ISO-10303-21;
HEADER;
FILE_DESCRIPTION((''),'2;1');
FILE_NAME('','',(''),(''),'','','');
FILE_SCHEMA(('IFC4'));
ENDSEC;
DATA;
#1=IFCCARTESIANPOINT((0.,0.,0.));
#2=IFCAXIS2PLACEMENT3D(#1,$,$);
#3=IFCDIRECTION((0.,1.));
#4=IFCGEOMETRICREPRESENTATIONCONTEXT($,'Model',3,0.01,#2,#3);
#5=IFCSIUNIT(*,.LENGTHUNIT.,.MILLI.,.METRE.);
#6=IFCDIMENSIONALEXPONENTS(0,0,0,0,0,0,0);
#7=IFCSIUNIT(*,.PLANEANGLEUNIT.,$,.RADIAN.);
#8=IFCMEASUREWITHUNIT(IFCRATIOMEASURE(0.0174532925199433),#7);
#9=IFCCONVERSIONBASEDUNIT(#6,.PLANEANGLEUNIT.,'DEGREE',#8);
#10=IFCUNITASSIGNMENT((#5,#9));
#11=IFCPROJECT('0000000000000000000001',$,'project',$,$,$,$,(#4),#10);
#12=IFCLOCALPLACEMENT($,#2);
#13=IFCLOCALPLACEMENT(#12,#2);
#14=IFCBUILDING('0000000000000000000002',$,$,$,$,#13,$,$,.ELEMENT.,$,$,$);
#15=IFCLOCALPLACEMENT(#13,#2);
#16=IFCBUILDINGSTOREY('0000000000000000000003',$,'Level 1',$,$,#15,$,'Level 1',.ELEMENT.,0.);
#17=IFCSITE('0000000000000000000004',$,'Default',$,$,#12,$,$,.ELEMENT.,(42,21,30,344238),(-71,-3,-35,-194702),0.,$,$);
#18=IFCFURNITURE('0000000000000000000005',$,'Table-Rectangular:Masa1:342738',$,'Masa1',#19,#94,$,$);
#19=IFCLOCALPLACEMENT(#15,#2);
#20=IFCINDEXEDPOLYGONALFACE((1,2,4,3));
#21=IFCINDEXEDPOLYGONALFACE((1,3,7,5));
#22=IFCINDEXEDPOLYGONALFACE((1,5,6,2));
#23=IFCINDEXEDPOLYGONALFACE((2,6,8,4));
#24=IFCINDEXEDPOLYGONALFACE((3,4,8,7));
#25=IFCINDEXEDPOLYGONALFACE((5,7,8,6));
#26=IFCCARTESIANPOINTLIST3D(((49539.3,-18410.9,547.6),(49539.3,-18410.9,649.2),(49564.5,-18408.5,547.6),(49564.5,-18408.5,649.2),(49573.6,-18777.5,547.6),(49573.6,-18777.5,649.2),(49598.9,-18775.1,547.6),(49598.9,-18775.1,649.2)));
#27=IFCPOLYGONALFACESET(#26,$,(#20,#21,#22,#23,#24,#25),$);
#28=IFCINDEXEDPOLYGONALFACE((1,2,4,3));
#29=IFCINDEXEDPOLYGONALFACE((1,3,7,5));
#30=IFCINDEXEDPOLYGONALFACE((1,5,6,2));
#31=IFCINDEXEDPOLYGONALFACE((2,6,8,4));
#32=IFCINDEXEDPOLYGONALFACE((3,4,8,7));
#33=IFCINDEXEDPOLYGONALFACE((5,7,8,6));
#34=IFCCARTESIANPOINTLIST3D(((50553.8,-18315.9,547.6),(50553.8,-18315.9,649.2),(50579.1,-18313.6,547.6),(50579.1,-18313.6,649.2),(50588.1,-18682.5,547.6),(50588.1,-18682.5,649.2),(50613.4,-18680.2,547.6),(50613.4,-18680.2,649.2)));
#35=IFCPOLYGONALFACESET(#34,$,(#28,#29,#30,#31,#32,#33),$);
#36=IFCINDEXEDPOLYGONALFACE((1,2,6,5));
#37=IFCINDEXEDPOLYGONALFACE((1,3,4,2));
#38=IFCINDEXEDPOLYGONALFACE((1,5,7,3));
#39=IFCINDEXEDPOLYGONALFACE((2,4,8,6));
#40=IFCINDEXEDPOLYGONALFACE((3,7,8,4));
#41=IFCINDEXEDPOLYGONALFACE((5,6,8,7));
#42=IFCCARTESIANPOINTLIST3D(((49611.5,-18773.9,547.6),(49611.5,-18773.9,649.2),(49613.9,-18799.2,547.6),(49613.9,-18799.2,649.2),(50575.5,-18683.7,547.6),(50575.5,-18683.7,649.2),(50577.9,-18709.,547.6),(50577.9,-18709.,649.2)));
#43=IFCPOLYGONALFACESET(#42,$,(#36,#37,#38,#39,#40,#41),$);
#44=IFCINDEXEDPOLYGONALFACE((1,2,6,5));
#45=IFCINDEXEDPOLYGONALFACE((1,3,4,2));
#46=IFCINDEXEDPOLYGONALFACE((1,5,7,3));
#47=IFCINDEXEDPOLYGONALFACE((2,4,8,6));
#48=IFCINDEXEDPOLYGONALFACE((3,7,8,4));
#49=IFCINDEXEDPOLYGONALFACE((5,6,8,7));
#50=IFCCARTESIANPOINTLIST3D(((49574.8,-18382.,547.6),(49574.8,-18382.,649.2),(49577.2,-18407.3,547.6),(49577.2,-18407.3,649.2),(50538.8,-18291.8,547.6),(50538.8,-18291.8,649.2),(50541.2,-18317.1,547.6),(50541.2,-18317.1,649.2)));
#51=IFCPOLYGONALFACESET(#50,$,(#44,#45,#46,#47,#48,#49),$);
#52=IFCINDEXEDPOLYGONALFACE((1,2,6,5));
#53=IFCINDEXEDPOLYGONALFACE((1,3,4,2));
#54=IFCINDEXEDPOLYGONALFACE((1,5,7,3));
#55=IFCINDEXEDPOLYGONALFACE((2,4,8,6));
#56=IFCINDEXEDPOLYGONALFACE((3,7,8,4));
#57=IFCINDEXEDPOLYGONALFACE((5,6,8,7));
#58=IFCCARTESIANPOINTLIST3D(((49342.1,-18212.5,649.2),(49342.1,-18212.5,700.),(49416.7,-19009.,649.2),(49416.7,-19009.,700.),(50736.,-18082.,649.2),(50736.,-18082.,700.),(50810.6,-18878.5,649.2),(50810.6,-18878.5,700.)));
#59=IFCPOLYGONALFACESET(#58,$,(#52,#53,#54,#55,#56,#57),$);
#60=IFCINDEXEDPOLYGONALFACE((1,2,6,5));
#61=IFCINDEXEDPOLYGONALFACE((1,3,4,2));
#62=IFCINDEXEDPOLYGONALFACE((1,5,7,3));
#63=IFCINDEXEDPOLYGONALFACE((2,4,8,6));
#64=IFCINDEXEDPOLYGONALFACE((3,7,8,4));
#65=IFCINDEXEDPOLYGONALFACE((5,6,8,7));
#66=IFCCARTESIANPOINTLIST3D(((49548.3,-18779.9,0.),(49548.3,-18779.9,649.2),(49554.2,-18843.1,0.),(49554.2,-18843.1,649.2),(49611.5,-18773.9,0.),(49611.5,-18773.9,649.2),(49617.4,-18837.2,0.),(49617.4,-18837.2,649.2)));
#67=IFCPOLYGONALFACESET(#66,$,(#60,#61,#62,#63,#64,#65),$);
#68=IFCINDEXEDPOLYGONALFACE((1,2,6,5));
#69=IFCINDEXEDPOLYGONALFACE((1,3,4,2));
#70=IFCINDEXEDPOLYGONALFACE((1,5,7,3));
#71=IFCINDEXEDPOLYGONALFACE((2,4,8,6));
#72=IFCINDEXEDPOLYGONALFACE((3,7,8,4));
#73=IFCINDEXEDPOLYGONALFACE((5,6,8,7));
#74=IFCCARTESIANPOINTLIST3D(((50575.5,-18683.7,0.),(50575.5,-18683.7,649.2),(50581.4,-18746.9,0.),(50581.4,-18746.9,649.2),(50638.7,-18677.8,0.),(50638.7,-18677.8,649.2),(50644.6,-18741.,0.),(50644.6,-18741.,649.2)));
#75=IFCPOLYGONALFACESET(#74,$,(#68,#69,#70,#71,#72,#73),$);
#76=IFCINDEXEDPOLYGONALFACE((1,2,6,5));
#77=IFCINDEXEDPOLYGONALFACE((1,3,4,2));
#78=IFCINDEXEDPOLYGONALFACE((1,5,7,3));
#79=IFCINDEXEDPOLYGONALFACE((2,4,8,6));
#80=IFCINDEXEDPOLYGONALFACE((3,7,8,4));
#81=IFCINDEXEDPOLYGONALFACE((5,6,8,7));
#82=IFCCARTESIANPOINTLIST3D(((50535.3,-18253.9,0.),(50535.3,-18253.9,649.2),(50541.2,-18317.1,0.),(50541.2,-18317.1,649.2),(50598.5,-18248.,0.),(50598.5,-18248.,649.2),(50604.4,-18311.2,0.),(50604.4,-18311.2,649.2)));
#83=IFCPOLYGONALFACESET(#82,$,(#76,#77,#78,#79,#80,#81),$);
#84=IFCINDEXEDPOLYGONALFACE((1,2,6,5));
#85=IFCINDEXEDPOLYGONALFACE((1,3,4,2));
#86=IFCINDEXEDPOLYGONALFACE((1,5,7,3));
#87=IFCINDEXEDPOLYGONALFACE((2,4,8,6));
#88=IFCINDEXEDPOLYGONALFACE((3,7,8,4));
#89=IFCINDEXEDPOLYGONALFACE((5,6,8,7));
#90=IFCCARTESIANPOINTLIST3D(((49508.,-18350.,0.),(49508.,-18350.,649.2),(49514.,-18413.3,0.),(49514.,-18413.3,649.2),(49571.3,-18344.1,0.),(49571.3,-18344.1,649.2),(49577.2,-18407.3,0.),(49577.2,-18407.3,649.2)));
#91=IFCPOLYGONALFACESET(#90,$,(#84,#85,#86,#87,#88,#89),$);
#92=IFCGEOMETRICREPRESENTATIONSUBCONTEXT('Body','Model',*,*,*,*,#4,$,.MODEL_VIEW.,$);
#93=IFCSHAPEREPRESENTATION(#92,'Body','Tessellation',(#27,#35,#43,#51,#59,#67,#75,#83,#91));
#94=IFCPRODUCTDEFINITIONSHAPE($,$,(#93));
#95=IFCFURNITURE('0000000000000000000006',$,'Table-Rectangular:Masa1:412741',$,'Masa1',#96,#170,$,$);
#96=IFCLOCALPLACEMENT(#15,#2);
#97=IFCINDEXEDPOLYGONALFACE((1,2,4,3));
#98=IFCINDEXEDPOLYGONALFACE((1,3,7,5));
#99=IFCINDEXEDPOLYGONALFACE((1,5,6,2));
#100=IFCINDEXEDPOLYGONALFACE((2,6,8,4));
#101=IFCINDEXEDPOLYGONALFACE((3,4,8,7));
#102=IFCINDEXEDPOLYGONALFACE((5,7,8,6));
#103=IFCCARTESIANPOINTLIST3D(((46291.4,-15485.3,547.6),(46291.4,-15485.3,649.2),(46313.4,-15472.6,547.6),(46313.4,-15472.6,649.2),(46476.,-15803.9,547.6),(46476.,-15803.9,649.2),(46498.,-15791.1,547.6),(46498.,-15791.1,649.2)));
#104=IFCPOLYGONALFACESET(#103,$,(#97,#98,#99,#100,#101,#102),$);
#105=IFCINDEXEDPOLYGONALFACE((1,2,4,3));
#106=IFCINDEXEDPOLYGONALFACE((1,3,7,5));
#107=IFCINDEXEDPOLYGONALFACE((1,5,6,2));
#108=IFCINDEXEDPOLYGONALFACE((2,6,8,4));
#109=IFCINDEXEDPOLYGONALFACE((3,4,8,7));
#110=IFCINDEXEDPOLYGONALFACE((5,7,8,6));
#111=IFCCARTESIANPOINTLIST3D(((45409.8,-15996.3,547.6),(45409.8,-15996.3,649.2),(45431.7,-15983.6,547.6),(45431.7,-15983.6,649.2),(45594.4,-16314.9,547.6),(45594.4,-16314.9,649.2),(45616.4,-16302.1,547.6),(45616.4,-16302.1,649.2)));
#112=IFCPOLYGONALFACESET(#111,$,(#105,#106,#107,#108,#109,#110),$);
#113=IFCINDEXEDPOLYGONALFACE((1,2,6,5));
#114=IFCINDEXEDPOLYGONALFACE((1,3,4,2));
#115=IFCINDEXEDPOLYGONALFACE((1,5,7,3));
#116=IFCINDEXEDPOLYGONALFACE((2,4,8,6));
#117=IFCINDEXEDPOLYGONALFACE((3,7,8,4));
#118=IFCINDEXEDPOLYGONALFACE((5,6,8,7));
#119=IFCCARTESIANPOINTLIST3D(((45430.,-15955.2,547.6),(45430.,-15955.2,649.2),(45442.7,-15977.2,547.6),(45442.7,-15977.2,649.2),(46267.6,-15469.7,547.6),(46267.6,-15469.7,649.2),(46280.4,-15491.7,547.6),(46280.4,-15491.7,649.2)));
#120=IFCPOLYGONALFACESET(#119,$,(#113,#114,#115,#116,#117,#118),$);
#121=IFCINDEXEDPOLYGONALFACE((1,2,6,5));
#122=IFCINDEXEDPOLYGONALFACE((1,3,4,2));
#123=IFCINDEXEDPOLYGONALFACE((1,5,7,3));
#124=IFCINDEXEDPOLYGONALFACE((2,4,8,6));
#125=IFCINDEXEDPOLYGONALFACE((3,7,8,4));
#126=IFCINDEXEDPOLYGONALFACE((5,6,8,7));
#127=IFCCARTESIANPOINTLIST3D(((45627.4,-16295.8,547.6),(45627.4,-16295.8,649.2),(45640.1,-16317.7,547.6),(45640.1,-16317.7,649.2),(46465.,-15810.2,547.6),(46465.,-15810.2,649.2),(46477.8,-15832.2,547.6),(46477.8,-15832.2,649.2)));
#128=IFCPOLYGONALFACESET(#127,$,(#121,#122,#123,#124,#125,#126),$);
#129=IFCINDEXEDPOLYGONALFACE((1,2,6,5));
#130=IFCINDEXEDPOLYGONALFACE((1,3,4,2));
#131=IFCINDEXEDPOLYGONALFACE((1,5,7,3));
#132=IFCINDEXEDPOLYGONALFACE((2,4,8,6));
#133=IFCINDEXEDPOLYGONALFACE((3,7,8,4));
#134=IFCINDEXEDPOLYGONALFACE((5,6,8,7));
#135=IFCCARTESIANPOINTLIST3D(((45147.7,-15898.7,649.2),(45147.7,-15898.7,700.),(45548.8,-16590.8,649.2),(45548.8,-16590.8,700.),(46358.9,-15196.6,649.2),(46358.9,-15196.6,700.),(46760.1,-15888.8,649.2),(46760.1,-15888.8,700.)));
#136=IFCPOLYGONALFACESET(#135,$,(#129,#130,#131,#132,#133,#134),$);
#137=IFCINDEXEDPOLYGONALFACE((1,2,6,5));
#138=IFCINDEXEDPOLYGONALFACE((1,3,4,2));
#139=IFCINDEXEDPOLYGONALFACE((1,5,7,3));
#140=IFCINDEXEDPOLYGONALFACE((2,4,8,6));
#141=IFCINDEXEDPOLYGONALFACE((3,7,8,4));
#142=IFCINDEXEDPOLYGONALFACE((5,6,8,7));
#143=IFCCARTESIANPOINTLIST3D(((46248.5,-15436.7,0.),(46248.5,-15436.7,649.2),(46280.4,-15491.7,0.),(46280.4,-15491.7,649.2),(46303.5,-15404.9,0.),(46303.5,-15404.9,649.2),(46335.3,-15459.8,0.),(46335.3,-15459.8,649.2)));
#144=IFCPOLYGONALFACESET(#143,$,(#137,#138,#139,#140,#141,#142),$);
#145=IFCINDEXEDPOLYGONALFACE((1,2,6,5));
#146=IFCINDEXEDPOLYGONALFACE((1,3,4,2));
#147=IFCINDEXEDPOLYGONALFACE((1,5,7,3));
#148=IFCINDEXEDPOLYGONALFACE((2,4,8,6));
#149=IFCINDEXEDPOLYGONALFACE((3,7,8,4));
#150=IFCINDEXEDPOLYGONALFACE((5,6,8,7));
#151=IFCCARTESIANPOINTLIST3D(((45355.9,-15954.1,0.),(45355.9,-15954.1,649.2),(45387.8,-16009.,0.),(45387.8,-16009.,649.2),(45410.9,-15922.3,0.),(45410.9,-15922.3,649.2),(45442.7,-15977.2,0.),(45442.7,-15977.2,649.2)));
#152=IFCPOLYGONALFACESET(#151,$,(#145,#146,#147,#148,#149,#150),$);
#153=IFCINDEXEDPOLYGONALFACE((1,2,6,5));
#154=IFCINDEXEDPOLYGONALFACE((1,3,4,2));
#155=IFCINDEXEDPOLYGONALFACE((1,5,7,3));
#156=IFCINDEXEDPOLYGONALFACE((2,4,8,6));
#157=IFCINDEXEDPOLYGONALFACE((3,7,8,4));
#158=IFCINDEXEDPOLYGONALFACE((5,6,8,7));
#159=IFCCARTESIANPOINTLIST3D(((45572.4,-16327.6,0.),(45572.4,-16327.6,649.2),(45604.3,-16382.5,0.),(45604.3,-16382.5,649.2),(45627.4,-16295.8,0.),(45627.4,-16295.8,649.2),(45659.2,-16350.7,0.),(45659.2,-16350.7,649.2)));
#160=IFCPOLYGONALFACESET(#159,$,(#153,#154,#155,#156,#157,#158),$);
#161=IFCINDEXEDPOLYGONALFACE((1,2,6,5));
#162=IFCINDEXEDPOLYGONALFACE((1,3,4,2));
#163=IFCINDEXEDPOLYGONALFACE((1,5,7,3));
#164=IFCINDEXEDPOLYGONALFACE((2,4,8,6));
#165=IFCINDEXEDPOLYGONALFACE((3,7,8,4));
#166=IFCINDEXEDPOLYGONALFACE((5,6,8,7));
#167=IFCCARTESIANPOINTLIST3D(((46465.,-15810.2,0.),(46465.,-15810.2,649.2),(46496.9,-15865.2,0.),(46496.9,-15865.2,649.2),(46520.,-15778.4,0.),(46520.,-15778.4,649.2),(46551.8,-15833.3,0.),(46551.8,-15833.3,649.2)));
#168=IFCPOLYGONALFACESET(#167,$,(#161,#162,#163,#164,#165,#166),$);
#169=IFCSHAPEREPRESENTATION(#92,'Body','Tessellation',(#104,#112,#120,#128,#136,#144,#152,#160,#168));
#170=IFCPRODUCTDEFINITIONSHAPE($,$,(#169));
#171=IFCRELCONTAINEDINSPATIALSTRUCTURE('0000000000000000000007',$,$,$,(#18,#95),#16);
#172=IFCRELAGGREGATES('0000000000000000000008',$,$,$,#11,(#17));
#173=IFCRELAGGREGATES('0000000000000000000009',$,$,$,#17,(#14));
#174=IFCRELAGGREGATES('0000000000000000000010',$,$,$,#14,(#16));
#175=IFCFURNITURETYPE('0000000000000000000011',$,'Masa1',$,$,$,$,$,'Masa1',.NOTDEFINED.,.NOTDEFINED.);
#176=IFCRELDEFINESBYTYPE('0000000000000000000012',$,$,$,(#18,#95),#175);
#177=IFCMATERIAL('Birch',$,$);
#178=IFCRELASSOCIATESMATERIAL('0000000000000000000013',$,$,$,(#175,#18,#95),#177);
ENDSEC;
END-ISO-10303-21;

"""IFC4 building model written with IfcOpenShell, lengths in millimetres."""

from ifc_helpers import new_model, entity, si_unit, converted_unit, direction, frame, frame_2d, origin, origin_2d_with_axis, place, context, subcontext, project, spatial, rectangle, extrude, source, transform, mapped, material, type_object, type_shapes, element, save


model = new_model("IFC4")

# Units and contexts
model_context = context("Model", 3, precision=0.01, world=origin(), true_north=direction((0.0, 1.0)))
body_context = subcontext(model_context, "Body", "Model", "MODEL_VIEW")
ifc_project = project(units=[si_unit("LENGTHUNIT", "METRE", prefix="MILLI"), converted_unit("PLANEANGLEUNIT", "DEGREE", entity("IfcRatioMeasure", 0.0174532925199433), si_unit("PLANEANGLEUNIT", "RADIAN"), dimensions=[0, 0, 0, 0, 0, 0, 0])], contexts=[model_context])

# Site, building, storey
site_placement = place(None, origin())
site = spatial("IfcSite", under=ifc_project, at=site_placement, Name="Default", CompositionType="ELEMENT", RefLatitude=(42, 21, 30, 344238), RefLongitude=(-71, -3, -35, -194702), RefElevation=0.0)
building_placement = place(site_placement, origin())
building = spatial("IfcBuilding", under=site, at=building_placement, CompositionType="ELEMENT")
storey_placement = place(building_placement, origin())
storey = spatial("IfcBuildingStorey", under=building, at=storey_placement, Name="Level 1", LongName="Level 1", CompositionType="ELEMENT", Elevation=0.0)

# Furniture
ifc_material_1 = material(Name="Birch")
furniture_type_1 = type_object("IfcFurnitureType", Name="Masa1", ElementType="Masa1", AssemblyPlace="NOTDEFINED", PredefinedType="NOTDEFINED", material=ifc_material_1)
shared_shape_1 = source(origin(), body_context, "Body", "SweptSolid", [
    extrude(rectangle(XDim=25.4, YDim=368.2, at=origin_2d_with_axis()), frame((509.5, 0.0, 547.6)), (0.0, 0.0, 1.0), 101.6),
    extrude(rectangle(XDim=368.2, YDim=25.4, at=origin_2d_with_axis()), frame((-509.5, 0.0, 547.6), z_axis=(0.0, 0.0, 1.0), x_axis=(0.0, 1.0, 0.0)), (0.0, 0.0, 1.0), 101.6),
    extrude(rectangle(XDim=968.2, YDim=25.4, at=frame_2d((0.0, 0.0), x_axis=(1.0, 0.0))), frame((0.0, 196.8, 547.6), z_axis=(0.0, 0.0, 1.0), x_axis=(-1.0, 0.0, 0.0)), (0.0, 0.0, 1.0), 101.6),
    extrude(rectangle(XDim=25.4, YDim=968.2, at=origin_2d_with_axis()), frame((0.0, -196.8, 547.6), z_axis=(0.0, 0.0, 1.0), x_axis=(0.0, 1.0, 0.0)), (0.0, 0.0, 1.0), 101.6),
    extrude(rectangle(XDim=1400.0, YDim=800.0, at=origin_2d_with_axis()), frame((0.0, 0.0, 649.2), z_axis=(0.0, 0.0, 1.0), x_axis=(-1.0, 0.0, 0.0)), (0.0, 0.0, 1.0), 50.8),
    extrude(rectangle(XDim=63.5, YDim=63.5, at=origin_2d_with_axis()), frame((515.9, 215.9, 0.0), z_axis=(0.0, 0.0, 1.0), x_axis=(0.0, -1.0, 0.0)), (0.0, 0.0, 1.0), 649.2),
    extrude(rectangle(XDim=63.5, YDim=63.5, at=origin_2d_with_axis()), frame((-515.9, 215.9, 0.0), z_axis=(0.0, 0.0, 1.0), x_axis=(-1.0, 0.0, 0.0)), (0.0, 0.0, 1.0), 649.2),
    extrude(rectangle(XDim=63.5, YDim=63.5, at=origin_2d_with_axis()), frame((-515.9, -215.9, 0.0), z_axis=(0.0, 0.0, 1.0), x_axis=(0.0, 1.0, 0.0)), (0.0, 0.0, 1.0), 649.2),
    extrude(rectangle(XDim=63.5, YDim=63.5, at=frame_2d((0.0, 0.0), x_axis=(1.0, 0.0))), frame((515.9, -215.9, 0.0)), (0.0, 0.0, 1.0), 649.2),
])
type_shapes(furniture_type_1, [shared_shape_1])
for number, where, z_axis, x_axis, name in (
    (1, (50076.3, -18545.5, 0.0), (0.0, 0.0, 1.0), (-0.995648, -0.093196, 0.0), "Table-Rectangular:Masa1:342738"),
    (2, (45953.9, -15893.7, 0.0), (0.0, 0.0, 1.0), (0.865177, 0.501466, 0.0), "Table-Rectangular:Masa1:412741"),
):
    element("IfcFurniture", number, at=place(storey_placement, frame(where, z_axis=z_axis, x_axis=x_axis)), inside=storey, type_object=furniture_type_1, material=ifc_material_1, Name=name, ObjectType="Masa1", context=body_context, shape_type="MappedRepresentation", body=[
        mapped(shared_shape_1, transform((0.0, 0.0, 0.0), scale=1.0)),
    ])

save(model, "model.ifc")
